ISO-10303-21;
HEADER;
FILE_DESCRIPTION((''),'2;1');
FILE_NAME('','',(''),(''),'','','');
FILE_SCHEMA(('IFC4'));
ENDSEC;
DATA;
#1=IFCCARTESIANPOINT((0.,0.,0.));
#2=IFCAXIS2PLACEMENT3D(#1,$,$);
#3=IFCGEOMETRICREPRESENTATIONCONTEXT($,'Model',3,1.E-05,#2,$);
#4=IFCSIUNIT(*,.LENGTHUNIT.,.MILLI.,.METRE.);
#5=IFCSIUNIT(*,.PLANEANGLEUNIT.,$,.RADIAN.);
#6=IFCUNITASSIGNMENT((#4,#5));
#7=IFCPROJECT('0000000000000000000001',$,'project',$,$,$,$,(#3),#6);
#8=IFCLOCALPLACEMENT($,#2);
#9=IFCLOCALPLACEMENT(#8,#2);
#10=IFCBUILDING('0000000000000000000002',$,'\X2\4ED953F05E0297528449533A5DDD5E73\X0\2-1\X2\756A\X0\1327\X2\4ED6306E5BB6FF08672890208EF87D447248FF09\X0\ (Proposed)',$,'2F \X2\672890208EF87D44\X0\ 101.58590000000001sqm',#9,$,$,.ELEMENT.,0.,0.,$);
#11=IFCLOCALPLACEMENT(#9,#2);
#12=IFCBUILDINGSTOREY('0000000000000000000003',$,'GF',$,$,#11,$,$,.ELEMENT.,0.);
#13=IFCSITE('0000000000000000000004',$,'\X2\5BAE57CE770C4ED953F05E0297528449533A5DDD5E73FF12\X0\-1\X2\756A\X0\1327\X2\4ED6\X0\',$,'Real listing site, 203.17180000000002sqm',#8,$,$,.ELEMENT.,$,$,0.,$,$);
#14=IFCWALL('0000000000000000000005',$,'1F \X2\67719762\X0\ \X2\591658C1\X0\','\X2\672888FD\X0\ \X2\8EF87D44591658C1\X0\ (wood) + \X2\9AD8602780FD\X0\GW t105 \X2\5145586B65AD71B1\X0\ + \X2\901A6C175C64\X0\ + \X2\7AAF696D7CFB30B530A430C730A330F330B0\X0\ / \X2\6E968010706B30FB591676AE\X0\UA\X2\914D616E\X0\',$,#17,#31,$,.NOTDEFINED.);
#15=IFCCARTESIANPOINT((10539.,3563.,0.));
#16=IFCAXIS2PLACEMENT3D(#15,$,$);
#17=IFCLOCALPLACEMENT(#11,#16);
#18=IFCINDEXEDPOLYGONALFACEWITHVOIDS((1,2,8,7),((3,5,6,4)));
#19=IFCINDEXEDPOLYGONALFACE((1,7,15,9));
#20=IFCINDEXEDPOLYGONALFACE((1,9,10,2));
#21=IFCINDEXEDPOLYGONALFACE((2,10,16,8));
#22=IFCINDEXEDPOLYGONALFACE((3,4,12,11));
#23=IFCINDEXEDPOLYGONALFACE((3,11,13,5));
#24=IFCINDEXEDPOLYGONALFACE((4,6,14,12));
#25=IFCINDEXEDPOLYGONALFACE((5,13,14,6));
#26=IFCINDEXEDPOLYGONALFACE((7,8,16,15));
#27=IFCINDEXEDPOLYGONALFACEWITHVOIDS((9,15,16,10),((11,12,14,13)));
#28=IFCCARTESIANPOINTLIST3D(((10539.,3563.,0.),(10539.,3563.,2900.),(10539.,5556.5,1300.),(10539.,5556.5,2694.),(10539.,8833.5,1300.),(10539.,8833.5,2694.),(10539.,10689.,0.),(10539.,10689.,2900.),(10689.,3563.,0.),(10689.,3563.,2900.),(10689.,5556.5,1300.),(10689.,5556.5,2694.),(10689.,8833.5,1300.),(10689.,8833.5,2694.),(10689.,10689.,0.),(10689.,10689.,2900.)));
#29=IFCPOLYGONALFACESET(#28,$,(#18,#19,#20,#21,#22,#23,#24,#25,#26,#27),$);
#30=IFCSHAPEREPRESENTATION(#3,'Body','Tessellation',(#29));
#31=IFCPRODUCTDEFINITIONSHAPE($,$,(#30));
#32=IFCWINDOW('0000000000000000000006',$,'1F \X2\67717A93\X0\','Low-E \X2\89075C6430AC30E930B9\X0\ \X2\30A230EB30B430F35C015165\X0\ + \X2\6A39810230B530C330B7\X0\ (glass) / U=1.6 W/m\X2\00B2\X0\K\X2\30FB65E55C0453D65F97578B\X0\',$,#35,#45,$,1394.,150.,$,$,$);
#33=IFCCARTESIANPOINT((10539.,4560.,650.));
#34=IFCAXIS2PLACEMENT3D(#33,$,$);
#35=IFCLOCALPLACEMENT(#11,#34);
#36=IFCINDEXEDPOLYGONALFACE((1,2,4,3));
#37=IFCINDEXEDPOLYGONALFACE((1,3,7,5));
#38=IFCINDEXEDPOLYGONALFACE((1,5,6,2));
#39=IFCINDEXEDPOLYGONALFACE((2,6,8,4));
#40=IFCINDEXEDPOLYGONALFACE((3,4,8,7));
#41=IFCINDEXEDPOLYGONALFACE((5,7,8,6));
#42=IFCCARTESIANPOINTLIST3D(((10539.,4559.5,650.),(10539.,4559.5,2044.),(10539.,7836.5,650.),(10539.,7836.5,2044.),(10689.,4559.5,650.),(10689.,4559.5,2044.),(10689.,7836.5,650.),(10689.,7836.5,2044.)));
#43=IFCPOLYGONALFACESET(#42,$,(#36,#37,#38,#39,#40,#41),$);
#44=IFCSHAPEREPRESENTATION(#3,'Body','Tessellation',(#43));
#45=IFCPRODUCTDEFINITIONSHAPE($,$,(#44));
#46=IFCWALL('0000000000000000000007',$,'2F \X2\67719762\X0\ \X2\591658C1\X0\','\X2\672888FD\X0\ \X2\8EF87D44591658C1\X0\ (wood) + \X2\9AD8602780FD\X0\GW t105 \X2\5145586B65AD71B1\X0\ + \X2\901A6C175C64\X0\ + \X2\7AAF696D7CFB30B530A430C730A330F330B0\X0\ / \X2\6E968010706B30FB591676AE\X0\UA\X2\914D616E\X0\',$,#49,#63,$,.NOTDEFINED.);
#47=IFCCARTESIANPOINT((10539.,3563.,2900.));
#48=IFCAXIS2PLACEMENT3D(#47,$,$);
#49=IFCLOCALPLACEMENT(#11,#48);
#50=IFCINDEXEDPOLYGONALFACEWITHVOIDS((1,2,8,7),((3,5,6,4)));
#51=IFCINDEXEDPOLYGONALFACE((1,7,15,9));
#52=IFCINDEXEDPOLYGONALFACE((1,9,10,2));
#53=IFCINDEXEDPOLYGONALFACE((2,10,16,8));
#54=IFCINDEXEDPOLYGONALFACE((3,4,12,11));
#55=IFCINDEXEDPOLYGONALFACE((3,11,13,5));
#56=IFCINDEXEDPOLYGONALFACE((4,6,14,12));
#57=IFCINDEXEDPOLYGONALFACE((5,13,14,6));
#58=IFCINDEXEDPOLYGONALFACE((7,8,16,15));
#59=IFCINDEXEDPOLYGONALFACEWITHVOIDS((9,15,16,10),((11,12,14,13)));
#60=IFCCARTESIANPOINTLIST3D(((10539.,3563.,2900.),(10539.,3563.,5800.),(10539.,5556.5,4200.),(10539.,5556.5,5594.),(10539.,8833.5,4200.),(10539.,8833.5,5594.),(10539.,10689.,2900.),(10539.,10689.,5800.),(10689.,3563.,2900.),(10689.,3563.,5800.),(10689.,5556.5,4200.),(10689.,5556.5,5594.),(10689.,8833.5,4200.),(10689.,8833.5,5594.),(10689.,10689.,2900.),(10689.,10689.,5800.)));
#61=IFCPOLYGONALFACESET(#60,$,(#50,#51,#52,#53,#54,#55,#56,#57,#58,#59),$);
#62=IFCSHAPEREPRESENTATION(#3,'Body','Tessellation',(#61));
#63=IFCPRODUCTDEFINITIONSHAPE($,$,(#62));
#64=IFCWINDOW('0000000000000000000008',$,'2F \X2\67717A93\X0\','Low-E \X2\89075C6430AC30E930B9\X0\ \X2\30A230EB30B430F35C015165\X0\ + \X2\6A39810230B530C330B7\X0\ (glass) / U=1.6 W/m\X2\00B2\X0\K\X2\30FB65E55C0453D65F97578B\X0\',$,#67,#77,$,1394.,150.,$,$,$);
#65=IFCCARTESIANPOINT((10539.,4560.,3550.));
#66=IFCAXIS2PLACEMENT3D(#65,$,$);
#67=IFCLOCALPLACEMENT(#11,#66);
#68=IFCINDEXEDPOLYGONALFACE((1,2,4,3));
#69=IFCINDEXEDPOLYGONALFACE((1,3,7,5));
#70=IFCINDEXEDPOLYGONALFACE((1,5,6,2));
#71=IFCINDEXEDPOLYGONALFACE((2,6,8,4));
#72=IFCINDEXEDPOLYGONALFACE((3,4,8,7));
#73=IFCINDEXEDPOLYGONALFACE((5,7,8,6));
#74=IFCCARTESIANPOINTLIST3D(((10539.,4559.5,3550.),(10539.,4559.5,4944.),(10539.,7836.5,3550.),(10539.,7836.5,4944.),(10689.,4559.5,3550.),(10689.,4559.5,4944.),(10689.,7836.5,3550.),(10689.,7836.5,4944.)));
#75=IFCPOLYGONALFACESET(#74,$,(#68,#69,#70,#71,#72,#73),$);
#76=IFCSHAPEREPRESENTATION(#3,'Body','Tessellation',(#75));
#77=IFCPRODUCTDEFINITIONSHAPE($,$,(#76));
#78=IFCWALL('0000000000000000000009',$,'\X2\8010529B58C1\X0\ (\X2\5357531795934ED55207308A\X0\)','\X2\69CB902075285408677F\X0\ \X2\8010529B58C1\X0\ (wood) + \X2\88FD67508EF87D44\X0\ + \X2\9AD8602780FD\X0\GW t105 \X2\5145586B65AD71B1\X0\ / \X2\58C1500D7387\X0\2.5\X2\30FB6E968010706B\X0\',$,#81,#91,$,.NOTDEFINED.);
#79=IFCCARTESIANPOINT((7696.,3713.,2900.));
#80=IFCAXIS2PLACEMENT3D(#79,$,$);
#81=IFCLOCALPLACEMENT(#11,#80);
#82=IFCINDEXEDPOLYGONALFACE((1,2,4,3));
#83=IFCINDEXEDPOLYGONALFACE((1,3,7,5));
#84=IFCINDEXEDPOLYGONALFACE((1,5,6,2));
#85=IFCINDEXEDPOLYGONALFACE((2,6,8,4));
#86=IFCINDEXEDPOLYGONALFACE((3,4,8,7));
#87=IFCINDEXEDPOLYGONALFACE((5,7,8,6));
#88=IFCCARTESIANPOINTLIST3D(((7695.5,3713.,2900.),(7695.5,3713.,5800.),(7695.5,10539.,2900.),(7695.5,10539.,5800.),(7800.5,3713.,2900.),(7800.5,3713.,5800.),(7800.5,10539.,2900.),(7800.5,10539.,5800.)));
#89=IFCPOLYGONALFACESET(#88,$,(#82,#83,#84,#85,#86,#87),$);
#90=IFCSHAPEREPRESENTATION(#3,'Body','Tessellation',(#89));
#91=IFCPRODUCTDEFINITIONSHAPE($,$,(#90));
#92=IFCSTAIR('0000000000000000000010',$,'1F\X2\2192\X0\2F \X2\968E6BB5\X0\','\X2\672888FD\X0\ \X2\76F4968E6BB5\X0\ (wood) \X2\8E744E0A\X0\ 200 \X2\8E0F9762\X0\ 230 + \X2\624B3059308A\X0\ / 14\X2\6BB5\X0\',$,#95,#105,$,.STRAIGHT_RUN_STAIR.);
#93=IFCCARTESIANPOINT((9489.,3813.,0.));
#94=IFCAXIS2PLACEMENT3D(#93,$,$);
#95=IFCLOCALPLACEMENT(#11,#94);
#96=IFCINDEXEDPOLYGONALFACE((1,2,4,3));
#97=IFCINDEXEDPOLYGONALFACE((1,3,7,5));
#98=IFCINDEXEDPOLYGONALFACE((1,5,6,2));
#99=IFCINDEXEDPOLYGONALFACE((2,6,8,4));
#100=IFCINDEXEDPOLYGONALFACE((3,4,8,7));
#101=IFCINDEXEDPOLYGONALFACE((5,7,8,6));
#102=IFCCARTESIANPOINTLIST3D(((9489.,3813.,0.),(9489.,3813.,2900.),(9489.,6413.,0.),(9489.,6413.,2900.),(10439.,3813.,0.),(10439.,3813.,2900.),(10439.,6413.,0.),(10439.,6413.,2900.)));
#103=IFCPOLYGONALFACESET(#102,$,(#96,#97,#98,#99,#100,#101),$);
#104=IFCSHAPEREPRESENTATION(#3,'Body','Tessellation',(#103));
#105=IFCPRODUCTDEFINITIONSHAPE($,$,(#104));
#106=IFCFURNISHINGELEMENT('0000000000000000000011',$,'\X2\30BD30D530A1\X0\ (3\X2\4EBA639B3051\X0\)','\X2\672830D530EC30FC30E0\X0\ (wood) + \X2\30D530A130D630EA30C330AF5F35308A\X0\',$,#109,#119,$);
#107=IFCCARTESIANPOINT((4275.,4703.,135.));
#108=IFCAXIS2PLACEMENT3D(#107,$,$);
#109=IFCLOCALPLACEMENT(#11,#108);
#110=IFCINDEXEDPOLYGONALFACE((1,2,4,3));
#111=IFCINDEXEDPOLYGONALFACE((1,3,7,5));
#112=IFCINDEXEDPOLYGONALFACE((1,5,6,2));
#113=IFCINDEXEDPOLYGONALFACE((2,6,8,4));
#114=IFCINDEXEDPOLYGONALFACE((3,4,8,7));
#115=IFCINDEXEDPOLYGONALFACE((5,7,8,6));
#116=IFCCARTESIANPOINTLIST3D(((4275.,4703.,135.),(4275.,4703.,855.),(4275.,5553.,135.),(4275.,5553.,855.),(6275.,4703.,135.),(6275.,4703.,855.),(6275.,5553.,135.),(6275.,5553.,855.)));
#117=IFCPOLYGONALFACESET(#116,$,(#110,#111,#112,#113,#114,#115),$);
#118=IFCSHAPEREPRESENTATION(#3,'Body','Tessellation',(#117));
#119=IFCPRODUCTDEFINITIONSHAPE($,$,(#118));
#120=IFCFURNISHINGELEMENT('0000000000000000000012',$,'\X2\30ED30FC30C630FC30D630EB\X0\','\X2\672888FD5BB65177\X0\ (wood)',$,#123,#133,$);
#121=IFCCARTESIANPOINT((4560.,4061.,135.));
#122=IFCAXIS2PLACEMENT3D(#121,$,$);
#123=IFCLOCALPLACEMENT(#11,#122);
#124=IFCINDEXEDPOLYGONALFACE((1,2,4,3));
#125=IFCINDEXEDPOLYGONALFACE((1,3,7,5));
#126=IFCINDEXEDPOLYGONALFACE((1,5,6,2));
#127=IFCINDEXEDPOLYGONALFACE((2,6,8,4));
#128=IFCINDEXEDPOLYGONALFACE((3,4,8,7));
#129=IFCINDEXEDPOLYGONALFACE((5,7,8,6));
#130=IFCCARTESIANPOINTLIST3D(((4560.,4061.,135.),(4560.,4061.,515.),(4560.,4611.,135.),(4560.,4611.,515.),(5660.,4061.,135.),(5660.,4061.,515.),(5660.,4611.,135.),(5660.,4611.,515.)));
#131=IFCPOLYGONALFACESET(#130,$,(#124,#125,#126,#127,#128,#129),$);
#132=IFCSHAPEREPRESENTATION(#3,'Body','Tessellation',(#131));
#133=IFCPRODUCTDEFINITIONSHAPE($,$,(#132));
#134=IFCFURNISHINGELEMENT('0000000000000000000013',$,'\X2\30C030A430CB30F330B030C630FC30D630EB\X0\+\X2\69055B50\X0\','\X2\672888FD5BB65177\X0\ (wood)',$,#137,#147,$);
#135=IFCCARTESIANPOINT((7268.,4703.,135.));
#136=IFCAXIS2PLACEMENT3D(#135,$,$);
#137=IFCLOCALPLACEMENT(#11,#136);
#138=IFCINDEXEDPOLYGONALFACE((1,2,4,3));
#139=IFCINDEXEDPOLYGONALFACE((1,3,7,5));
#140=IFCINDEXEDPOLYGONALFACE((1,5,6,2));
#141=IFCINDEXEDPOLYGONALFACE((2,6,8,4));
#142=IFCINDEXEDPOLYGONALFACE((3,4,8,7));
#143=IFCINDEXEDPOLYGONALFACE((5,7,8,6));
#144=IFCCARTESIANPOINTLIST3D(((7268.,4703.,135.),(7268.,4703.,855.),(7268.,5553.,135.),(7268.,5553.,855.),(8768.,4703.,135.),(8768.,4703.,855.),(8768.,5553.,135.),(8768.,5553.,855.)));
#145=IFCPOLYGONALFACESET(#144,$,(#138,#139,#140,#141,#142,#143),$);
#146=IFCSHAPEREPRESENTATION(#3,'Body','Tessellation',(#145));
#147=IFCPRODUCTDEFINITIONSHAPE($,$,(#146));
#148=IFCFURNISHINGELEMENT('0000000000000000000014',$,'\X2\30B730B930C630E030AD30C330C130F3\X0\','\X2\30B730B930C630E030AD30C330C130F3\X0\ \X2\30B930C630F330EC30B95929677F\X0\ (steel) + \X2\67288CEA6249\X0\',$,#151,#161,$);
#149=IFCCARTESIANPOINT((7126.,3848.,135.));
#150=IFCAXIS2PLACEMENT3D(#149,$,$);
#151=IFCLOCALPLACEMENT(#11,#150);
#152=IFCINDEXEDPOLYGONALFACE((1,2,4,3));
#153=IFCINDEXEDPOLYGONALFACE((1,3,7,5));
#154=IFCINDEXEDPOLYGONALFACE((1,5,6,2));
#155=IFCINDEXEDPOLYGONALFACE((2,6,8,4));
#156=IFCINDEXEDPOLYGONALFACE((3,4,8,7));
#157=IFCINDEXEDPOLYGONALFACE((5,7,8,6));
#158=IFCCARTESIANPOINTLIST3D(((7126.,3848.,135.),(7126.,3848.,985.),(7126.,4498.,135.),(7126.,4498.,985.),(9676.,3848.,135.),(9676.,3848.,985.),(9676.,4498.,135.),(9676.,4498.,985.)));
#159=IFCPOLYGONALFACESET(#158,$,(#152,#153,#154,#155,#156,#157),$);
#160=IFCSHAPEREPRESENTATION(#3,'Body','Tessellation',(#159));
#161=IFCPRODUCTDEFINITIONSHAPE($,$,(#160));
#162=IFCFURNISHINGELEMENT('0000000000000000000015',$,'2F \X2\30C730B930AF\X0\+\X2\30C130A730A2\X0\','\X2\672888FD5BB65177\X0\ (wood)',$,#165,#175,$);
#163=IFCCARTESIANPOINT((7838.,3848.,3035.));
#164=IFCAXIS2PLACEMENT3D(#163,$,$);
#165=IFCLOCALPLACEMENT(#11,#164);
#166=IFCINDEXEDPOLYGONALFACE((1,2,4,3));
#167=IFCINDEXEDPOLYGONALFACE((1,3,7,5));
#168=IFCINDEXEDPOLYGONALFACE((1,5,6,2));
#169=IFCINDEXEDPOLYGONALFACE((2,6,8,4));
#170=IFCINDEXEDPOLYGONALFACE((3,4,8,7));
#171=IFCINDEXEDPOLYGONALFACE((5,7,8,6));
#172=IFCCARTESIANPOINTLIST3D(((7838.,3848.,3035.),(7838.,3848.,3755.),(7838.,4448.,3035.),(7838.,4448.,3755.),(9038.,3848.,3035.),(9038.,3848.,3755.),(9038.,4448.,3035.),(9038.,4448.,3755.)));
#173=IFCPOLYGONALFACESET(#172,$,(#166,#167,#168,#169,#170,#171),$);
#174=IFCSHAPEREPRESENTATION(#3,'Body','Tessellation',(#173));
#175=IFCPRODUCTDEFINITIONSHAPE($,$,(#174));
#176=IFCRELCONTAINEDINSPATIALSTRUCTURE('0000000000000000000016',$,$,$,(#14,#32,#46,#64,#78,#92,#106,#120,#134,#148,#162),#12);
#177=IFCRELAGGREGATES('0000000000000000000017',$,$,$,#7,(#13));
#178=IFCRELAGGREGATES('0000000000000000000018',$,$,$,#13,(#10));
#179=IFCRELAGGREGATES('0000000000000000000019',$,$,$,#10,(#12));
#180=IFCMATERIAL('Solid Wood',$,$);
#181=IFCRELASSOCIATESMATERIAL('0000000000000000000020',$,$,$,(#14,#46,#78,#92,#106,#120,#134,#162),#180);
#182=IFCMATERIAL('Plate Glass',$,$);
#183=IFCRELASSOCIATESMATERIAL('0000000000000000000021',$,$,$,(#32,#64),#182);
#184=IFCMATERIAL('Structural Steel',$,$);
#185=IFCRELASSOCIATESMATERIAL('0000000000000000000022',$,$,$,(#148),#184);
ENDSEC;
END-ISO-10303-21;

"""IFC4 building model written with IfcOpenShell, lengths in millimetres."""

from ifc_helpers import new_model, si_unit, frame, frame_2d, origin, place, context, project, spatial, rectangle, extrude, material, element, fill, save


model = new_model("IFC4")

# Units and contexts
model_context = context("Model", 3, precision=1e-05, world=origin())
ifc_project = project(units=[si_unit("LENGTHUNIT", "METRE", prefix="MILLI"), si_unit("PLANEANGLEUNIT", "RADIAN")], contexts=[model_context])

# Site, building, storey
site_placement = place(None, origin())
site = spatial("IfcSite", under=ifc_project, at=site_placement, Name="宮城県仙台市青葉区川平２-1番1327他", ObjectType="Real listing site, 203.17180000000002sqm", CompositionType="ELEMENT", RefElevation=0.0)
building_placement = place(site_placement, origin())
building = spatial("IfcBuilding", under=site, at=building_placement, Name="仙台市青葉区川平2-1番1327他の家（木造軸組版） (Proposed)", ObjectType="2F 木造軸組 101.58590000000001sqm", CompositionType="ELEMENT", ElevationOfRefHeight=0.0, ElevationOfTerrain=0.0)
storey_placement = place(building_placement, origin())
storey = spatial("IfcBuildingStorey", under=building, at=storey_placement, Name="GF", CompositionType="ELEMENT", Elevation=0.0)

# Wall, opening, window
ifc_material_1 = material(Name="Solid Wood")
wall_1_placement = place(storey_placement, frame((10539.0, 3563.0, 0.0)))
wall_1 = element("IfcWall", 1, at=wall_1_placement, inside=storey, material=ifc_material_1, Name="1F 東面 外壁", Description="木製 軸組外壁 (wood) + 高性能GW t105 充填断熱 + 通気層 + 窯業系サイディング / 準耐火・外皮UA配慮", PredefinedType="NOTDEFINED", context=model_context, shape_type="SweptSolid", body=[
    extrude(rectangle(XDim=150.0, YDim=7126.0, at=frame_2d((75.0, 3563.0))), frame((10539.0, 3563.0, 0.0)), (0.0, 0.0, 1.0), 2900.0),
])
opening_1_placement = place(storey_placement, frame((10539.0, 4560.0, 650.0)))
opening_1 = element("IfcOpeningElement", 2, at=opening_1_placement, cuts=wall_1, PredefinedType="NOTDEFINED", context=model_context, shape_type="SweptSolid", body=[
    extrude(rectangle(XDim=150.0, YDim=3277.0, at=frame_2d((75.0, 1638.0))), frame((10539.0, 4560.0, 650.0)), (0.0, 0.0, 1.0), 1394.0),
])
ifc_material_2 = material(Name="Plate Glass")
window_1_placement = place(storey_placement, frame((10539.0, 4560.0, 650.0)))
window_1 = element("IfcWindow", 3, at=window_1_placement, inside=storey, material=ifc_material_2, Name="1F 東窓", Description="Low-E 複層ガラス アルゴン封入 + 樹脂サッシ (glass) / U=1.6 W/m²K・日射取得型", OverallHeight=1394.0, OverallWidth=150.0, context=model_context, shape_type="SweptSolid", body=[
    extrude(rectangle(XDim=150.0, YDim=3277.0, at=frame_2d((75.0, 1638.0))), frame((10539.0, 4560.0, 650.0)), (0.0, 0.0, 1.0), 1394.0),
])
fill(opening_1, window_1)

# Wall, opening, window
wall_2_placement = place(storey_placement, frame((10539.0, 3563.0, 2900.0)))
wall_2 = element("IfcWall", 4, at=wall_2_placement, inside=storey, material=ifc_material_1, Name="2F 東面 外壁", Description="木製 軸組外壁 (wood) + 高性能GW t105 充填断熱 + 通気層 + 窯業系サイディング / 準耐火・外皮UA配慮", PredefinedType="NOTDEFINED", context=model_context, shape_type="SweptSolid", body=[
    extrude(rectangle(XDim=150.0, YDim=7126.0, at=frame_2d((75.0, 3563.0))), frame((10539.0, 3563.0, 2900.0)), (0.0, 0.0, 1.0), 2900.0),
])
opening_2_placement = place(storey_placement, frame((10539.0, 4560.0, 3550.0)))
opening_2 = element("IfcOpeningElement", 5, at=opening_2_placement, cuts=wall_2, PredefinedType="NOTDEFINED", context=model_context, shape_type="SweptSolid", body=[
    extrude(rectangle(XDim=150.0, YDim=3277.0, at=frame_2d((75.0, 1638.0))), frame((10539.0, 4560.0, 3550.0)), (0.0, 0.0, 1.0), 1394.0),
])
window_2_placement = place(storey_placement, frame((10539.0, 4560.0, 3550.0)))
window_2 = element("IfcWindow", 6, at=window_2_placement, inside=storey, material=ifc_material_2, Name="2F 東窓", Description="Low-E 複層ガラス アルゴン封入 + 樹脂サッシ (glass) / U=1.6 W/m²K・日射取得型", OverallHeight=1394.0, OverallWidth=150.0, context=model_context, shape_type="SweptSolid", body=[
    extrude(rectangle(XDim=150.0, YDim=3277.0, at=frame_2d((75.0, 1638.0))), frame((10539.0, 4560.0, 3550.0)), (0.0, 0.0, 1.0), 1394.0),
])
fill(opening_2, window_2)

# Wall
wall_3_placement = place(storey_placement, frame((7696.0, 3713.0, 2900.0)))
element("IfcWall", 7, at=wall_3_placement, inside=storey, material=ifc_material_1, Name="耐力壁 (南北間仕切り)", Description="構造用合板 耐力壁 (wood) + 製材軸組 + 高性能GW t105 充填断熱 / 壁倍率2.5・準耐火", PredefinedType="NOTDEFINED", context=model_context, shape_type="SweptSolid", body=[
    extrude(rectangle(XDim=105.0, YDim=6826.0, at=frame_2d((52.0, 3413.0))), frame((7696.0, 3713.0, 2900.0)), (0.0, 0.0, 1.0), 2900.0),
])

# Stair
stair_placement = place(storey_placement, frame((9489.0, 3813.0, 0.0)))
element("IfcStair", 8, at=stair_placement, inside=storey, material=ifc_material_1, Name="1F→2F 階段", Description="木製 直階段 (wood) 蹴上 200 踏面 230 + 手すり / 14段", PredefinedType="STRAIGHT_RUN_STAIR", context=model_context, shape_type="SweptSolid", body=[
    extrude(rectangle(XDim=950.0, YDim=2600.0, at=frame_2d((475.0, 1300.0))), frame((9489.0, 3813.0, 0.0)), (0.0, 0.0, 1.0), 2900.0),
])

# Furnishing elements
furnishing_1_placement = place(storey_placement, frame((4275.0, 4703.0, 135.0)))
element("IfcFurnishingElement", 9, at=furnishing_1_placement, inside=storey, material=ifc_material_1, Name="ソファ (3人掛け)", Description="木フレーム (wood) + ファブリック張り", context=model_context, shape_type="SweptSolid", body=[
    extrude(rectangle(XDim=2000.0, YDim=850.0, at=frame_2d((1000.0, 425.0))), frame((4275.0, 4703.0, 135.0)), (0.0, 0.0, 1.0), 720.0),
])
furnishing_2_placement = place(storey_placement, frame((4560.0, 4061.0, 135.0)))
element("IfcFurnishingElement", 10, at=furnishing_2_placement, inside=storey, material=ifc_material_1, Name="ローテーブル", Description="木製家具 (wood)", context=model_context, shape_type="SweptSolid", body=[
    extrude(rectangle(XDim=1100.0, YDim=550.0, at=frame_2d((550.0, 275.0))), frame((4560.0, 4061.0, 135.0)), (0.0, 0.0, 1.0), 380.0),
])
furnishing_3_placement = place(storey_placement, frame((7268.0, 4703.0, 135.0)))
element("IfcFurnishingElement", 11, at=furnishing_3_placement, inside=storey, material=ifc_material_1, Name="ダイニングテーブル+椅子", Description="木製家具 (wood)", context=model_context, shape_type="SweptSolid", body=[
    extrude(rectangle(XDim=1500.0, YDim=850.0, at=frame_2d((750.0, 425.0))), frame((7268.0, 4703.0, 135.0)), (0.0, 0.0, 1.0), 720.0),
])
ifc_material_3 = material(Name="Structural Steel")
furnishing_4_placement = place(storey_placement, frame((7126.0, 3848.0, 135.0)))
element("IfcFurnishingElement", 12, at=furnishing_4_placement, inside=storey, material=ifc_material_3, Name="システムキッチン", Description="システムキッチン ステンレス天板 (steel) + 木質扉", context=model_context, shape_type="SweptSolid", body=[
    extrude(rectangle(XDim=2550.0, YDim=650.0, at=frame_2d((1275.0, 325.0))), frame((7126.0, 3848.0, 135.0)), (0.0, 0.0, 1.0), 850.0),
])
furnishing_5_placement = place(storey_placement, frame((7838.0, 3848.0, 3035.0)))
element("IfcFurnishingElement", 13, at=furnishing_5_placement, inside=storey, material=ifc_material_1, Name="2F デスク+チェア", Description="木製家具 (wood)", context=model_context, shape_type="SweptSolid", body=[
    extrude(rectangle(XDim=1200.0, YDim=600.0, at=frame_2d((600.0, 300.0))), frame((7838.0, 3848.0, 3035.0)), (0.0, 0.0, 1.0), 720.0),
])

save(model, "model.ifc")
